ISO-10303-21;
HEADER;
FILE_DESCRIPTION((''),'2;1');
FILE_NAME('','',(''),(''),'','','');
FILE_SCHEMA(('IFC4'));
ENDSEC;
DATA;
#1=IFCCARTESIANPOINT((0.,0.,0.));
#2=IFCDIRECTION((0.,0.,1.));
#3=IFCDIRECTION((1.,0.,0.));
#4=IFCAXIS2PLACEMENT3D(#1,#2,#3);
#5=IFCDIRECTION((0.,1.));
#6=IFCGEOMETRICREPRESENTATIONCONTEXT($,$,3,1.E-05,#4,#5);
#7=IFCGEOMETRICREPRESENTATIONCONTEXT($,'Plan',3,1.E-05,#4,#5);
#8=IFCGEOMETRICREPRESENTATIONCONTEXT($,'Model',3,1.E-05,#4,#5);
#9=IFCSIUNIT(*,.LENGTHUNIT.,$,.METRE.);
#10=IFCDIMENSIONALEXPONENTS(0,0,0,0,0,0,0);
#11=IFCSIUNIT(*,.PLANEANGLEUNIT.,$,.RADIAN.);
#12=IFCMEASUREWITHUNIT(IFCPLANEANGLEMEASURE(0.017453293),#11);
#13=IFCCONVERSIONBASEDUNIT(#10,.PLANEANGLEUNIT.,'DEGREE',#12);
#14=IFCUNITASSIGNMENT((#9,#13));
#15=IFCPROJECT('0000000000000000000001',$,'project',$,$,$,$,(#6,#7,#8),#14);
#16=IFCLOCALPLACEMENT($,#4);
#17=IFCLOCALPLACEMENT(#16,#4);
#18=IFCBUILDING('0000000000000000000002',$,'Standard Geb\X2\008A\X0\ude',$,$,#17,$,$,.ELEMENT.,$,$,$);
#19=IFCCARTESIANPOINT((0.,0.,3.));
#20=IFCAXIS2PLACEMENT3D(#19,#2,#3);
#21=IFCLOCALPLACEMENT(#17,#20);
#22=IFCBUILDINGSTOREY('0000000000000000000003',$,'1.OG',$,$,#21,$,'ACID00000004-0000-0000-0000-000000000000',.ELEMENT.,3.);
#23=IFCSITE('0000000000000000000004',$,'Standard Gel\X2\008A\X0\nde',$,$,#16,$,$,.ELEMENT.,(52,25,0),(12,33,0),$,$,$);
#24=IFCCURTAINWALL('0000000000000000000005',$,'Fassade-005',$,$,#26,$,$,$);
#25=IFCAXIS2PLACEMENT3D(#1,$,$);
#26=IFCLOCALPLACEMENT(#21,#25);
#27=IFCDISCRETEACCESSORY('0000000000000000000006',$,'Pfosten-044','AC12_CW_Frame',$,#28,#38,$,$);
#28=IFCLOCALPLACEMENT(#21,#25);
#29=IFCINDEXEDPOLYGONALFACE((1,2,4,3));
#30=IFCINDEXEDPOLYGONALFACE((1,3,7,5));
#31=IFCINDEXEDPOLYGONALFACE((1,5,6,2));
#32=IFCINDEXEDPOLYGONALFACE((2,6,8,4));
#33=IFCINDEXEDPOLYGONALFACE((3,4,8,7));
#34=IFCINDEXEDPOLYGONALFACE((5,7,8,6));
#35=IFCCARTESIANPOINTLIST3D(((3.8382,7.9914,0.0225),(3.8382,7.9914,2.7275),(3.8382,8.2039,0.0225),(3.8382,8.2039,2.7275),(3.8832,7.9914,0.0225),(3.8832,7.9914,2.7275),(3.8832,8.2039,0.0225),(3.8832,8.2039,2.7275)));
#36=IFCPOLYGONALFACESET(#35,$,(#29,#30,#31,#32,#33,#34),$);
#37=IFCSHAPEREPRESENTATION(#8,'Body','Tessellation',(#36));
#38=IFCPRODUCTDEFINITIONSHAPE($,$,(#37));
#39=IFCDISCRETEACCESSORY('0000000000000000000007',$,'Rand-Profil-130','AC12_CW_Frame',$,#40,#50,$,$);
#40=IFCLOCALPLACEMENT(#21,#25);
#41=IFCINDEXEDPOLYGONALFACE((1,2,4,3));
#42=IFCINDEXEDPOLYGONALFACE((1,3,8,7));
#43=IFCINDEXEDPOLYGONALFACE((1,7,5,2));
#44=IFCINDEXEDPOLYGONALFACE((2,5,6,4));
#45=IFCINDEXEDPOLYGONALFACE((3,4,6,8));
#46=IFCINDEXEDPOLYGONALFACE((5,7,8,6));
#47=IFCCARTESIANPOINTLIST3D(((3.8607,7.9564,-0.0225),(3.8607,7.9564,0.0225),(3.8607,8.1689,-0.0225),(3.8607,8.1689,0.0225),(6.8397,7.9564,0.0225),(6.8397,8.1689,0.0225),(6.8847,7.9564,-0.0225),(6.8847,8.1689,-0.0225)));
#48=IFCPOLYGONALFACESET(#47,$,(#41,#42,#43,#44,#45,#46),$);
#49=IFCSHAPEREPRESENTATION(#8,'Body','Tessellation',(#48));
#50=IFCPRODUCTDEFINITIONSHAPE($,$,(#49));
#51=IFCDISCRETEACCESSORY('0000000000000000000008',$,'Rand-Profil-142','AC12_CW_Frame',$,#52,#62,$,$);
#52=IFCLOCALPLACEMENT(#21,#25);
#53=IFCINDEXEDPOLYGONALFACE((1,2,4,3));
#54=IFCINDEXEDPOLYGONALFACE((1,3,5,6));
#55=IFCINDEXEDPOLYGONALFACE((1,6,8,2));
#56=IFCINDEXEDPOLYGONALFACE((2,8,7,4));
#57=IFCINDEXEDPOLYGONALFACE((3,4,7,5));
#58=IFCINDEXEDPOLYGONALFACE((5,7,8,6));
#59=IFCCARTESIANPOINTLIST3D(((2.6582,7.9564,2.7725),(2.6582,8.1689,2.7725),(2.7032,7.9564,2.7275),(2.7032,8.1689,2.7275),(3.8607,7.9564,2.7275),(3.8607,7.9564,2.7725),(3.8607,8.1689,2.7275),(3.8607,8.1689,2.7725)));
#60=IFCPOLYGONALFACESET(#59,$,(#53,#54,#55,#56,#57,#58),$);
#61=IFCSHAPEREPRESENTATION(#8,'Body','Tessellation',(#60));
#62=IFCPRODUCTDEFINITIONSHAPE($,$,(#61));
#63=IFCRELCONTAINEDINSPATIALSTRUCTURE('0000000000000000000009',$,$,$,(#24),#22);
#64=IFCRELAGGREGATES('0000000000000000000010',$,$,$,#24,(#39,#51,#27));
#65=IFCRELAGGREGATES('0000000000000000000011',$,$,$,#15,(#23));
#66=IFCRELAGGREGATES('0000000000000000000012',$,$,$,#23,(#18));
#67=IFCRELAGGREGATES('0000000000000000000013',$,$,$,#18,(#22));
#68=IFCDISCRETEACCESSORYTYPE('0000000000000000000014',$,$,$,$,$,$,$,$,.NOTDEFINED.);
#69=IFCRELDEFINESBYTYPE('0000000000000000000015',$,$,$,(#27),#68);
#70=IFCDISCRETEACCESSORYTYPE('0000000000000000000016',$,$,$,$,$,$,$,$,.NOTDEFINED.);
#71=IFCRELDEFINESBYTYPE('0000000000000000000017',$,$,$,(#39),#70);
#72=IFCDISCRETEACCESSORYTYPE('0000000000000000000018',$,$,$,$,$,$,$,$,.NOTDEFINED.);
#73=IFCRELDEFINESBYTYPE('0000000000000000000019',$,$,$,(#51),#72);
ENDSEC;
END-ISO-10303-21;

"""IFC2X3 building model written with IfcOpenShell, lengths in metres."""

from ifc_helpers import new_model, entity, si_unit, converted_unit, direction, frame, origin_with_axes, place, context, project, spatial, polyline, outline, extrude, source, transform, mapped, type_object, type_shapes, element, aggregate, save


model = new_model("IFC2X3")

# Units and contexts
model_context = context("Model", 3, precision=1e-05, world=origin_with_axes(), true_north=direction((0.0, 1.0)))
plan_context = context("Plan", 3, precision=1e-05, world=origin_with_axes(), true_north=direction((0.0, 1.0)))
context_of_model = context(None, 3, precision=1e-05, world=origin_with_axes(), true_north=direction((0.0, 1.0)))
ifc_project = project(units=[si_unit("LENGTHUNIT", "METRE"), converted_unit("PLANEANGLEUNIT", "DEGREE", entity("IfcPlaneAngleMeasure", 0.017453293), si_unit("PLANEANGLEUNIT", "RADIAN"), dimensions=[0, 0, 0, 0, 0, 0, 0])], contexts=[context_of_model, plan_context, model_context])

# Site, building, storey
site_placement = place(None, origin_with_axes())
site = spatial("IfcSite", under=ifc_project, at=site_placement, Name="Standard Gel\u008ande", CompositionType="ELEMENT", RefLatitude=(52, 25, 0), RefLongitude=(12, 33, 0))
building_placement = place(site_placement, origin_with_axes())
building = spatial("IfcBuilding", under=site, at=building_placement, Name="Standard Geb\u008aude", CompositionType="ELEMENT")
storey_placement = place(building_placement, frame((0.0, 0.0, 3.0), z_axis=(0.0, 0.0, 1.0), x_axis=(1.0, 0.0, 0.0)))
storey = spatial("IfcBuildingStorey", under=building, at=storey_placement, Name="1.OG", LongName="ACID00000004-0000-0000-0000-000000000000", CompositionType="ELEMENT", Elevation=3.0)

# Curtain wall
curtain_wall_placement = place(storey_placement, frame((2.6807, 7.9914, 0.0), z_axis=(0.0, 0.0, 1.0), x_axis=(1.0, 0.0, 0.0)))
curtain_wall = element("IfcCurtainWall", 1, at=curtain_wall_placement, inside=storey, Name="Fassade-005")

# Discrete accessories
discrete_accessory_type_1 = type_object("IfcDiscreteAccessoryType")
shared_shape_1 = source(origin_with_axes(), model_context, "Body", "SweptSolid", [
    extrude(outline(polyline([(0.0, 0.0), (0.2125, 0.0), (0.2125, -2.705), (0.0, -2.705), (0.0, 0.0)])), origin_with_axes(), (0.0, 0.0, 1.0), 0.045),
])
type_shapes(discrete_accessory_type_1, [shared_shape_1])
discrete_accessory_1_placement = place(storey_placement, frame((3.8382, 8.2039, 0.0225), z_axis=(1.0, 0.0, 0.0), x_axis=(0.0, -1.0, 0.0)))
discrete_accessory_1 = element("IfcDiscreteAccessory", 2, at=discrete_accessory_1_placement, type_object=discrete_accessory_type_1, Name="Pfosten-044", Description="AC12_CW_Frame", context=model_context, shape_type="MappedRepresentation", body=[
    mapped(shared_shape_1, transform((0.0, 0.0, 0.0), scale=1.0)),
])
discrete_accessory_type_2 = type_object("IfcDiscreteAccessoryType")
shared_shape_2 = source(origin_with_axes(), model_context, "Body", "SweptSolid", [
    extrude(outline(polyline([(0.0, 0.0), (0.045, 0.0), (0.045, -3.024), (0.0, -2.979), (0.0, 0.0)])), origin_with_axes(), (0.0, 0.0, 1.0), 0.2125),
])
type_shapes(discrete_accessory_type_2, [shared_shape_2])
discrete_accessory_2_placement = place(storey_placement, frame((3.8607, 7.9564, 0.0225), z_axis=(0.0, 1.0, 0.0), x_axis=(0.0, 0.0, -1.0)))
discrete_accessory_2 = element("IfcDiscreteAccessory", 3, at=discrete_accessory_2_placement, type_object=discrete_accessory_type_2, Name="Rand-Profil-130", Description="AC12_CW_Frame", context=model_context, shape_type="MappedRepresentation", body=[
    mapped(shared_shape_2, transform((0.0, 0.0, 0.0), scale=1.0)),
])
discrete_accessory_type_3 = type_object("IfcDiscreteAccessoryType")
shared_shape_3 = source(origin_with_axes(), model_context, "Body", "SweptSolid", [
    extrude(outline(polyline([(0.0, 0.0), (0.045, 0.0), (0.045, -1.2025), (0.0, -1.1575), (0.0, 0.0)])), origin_with_axes(), (0.0, 0.0, 1.0), 0.2125),
])
type_shapes(discrete_accessory_type_3, [shared_shape_3])
discrete_accessory_3_placement = place(storey_placement, frame((3.8607, 7.9564, 2.7275), z_axis=(0.0, 1.0, 0.0), x_axis=(0.0, 0.0, 1.0)))
discrete_accessory_3 = element("IfcDiscreteAccessory", 4, at=discrete_accessory_3_placement, type_object=discrete_accessory_type_3, Name="Rand-Profil-142", Description="AC12_CW_Frame", context=model_context, shape_type="MappedRepresentation", body=[
    mapped(shared_shape_3, transform((0.0, 0.0, 0.0), scale=1.0)),
])
aggregate(curtain_wall, [discrete_accessory_2, discrete_accessory_3, discrete_accessory_1])

save(model, "model.ifc")
